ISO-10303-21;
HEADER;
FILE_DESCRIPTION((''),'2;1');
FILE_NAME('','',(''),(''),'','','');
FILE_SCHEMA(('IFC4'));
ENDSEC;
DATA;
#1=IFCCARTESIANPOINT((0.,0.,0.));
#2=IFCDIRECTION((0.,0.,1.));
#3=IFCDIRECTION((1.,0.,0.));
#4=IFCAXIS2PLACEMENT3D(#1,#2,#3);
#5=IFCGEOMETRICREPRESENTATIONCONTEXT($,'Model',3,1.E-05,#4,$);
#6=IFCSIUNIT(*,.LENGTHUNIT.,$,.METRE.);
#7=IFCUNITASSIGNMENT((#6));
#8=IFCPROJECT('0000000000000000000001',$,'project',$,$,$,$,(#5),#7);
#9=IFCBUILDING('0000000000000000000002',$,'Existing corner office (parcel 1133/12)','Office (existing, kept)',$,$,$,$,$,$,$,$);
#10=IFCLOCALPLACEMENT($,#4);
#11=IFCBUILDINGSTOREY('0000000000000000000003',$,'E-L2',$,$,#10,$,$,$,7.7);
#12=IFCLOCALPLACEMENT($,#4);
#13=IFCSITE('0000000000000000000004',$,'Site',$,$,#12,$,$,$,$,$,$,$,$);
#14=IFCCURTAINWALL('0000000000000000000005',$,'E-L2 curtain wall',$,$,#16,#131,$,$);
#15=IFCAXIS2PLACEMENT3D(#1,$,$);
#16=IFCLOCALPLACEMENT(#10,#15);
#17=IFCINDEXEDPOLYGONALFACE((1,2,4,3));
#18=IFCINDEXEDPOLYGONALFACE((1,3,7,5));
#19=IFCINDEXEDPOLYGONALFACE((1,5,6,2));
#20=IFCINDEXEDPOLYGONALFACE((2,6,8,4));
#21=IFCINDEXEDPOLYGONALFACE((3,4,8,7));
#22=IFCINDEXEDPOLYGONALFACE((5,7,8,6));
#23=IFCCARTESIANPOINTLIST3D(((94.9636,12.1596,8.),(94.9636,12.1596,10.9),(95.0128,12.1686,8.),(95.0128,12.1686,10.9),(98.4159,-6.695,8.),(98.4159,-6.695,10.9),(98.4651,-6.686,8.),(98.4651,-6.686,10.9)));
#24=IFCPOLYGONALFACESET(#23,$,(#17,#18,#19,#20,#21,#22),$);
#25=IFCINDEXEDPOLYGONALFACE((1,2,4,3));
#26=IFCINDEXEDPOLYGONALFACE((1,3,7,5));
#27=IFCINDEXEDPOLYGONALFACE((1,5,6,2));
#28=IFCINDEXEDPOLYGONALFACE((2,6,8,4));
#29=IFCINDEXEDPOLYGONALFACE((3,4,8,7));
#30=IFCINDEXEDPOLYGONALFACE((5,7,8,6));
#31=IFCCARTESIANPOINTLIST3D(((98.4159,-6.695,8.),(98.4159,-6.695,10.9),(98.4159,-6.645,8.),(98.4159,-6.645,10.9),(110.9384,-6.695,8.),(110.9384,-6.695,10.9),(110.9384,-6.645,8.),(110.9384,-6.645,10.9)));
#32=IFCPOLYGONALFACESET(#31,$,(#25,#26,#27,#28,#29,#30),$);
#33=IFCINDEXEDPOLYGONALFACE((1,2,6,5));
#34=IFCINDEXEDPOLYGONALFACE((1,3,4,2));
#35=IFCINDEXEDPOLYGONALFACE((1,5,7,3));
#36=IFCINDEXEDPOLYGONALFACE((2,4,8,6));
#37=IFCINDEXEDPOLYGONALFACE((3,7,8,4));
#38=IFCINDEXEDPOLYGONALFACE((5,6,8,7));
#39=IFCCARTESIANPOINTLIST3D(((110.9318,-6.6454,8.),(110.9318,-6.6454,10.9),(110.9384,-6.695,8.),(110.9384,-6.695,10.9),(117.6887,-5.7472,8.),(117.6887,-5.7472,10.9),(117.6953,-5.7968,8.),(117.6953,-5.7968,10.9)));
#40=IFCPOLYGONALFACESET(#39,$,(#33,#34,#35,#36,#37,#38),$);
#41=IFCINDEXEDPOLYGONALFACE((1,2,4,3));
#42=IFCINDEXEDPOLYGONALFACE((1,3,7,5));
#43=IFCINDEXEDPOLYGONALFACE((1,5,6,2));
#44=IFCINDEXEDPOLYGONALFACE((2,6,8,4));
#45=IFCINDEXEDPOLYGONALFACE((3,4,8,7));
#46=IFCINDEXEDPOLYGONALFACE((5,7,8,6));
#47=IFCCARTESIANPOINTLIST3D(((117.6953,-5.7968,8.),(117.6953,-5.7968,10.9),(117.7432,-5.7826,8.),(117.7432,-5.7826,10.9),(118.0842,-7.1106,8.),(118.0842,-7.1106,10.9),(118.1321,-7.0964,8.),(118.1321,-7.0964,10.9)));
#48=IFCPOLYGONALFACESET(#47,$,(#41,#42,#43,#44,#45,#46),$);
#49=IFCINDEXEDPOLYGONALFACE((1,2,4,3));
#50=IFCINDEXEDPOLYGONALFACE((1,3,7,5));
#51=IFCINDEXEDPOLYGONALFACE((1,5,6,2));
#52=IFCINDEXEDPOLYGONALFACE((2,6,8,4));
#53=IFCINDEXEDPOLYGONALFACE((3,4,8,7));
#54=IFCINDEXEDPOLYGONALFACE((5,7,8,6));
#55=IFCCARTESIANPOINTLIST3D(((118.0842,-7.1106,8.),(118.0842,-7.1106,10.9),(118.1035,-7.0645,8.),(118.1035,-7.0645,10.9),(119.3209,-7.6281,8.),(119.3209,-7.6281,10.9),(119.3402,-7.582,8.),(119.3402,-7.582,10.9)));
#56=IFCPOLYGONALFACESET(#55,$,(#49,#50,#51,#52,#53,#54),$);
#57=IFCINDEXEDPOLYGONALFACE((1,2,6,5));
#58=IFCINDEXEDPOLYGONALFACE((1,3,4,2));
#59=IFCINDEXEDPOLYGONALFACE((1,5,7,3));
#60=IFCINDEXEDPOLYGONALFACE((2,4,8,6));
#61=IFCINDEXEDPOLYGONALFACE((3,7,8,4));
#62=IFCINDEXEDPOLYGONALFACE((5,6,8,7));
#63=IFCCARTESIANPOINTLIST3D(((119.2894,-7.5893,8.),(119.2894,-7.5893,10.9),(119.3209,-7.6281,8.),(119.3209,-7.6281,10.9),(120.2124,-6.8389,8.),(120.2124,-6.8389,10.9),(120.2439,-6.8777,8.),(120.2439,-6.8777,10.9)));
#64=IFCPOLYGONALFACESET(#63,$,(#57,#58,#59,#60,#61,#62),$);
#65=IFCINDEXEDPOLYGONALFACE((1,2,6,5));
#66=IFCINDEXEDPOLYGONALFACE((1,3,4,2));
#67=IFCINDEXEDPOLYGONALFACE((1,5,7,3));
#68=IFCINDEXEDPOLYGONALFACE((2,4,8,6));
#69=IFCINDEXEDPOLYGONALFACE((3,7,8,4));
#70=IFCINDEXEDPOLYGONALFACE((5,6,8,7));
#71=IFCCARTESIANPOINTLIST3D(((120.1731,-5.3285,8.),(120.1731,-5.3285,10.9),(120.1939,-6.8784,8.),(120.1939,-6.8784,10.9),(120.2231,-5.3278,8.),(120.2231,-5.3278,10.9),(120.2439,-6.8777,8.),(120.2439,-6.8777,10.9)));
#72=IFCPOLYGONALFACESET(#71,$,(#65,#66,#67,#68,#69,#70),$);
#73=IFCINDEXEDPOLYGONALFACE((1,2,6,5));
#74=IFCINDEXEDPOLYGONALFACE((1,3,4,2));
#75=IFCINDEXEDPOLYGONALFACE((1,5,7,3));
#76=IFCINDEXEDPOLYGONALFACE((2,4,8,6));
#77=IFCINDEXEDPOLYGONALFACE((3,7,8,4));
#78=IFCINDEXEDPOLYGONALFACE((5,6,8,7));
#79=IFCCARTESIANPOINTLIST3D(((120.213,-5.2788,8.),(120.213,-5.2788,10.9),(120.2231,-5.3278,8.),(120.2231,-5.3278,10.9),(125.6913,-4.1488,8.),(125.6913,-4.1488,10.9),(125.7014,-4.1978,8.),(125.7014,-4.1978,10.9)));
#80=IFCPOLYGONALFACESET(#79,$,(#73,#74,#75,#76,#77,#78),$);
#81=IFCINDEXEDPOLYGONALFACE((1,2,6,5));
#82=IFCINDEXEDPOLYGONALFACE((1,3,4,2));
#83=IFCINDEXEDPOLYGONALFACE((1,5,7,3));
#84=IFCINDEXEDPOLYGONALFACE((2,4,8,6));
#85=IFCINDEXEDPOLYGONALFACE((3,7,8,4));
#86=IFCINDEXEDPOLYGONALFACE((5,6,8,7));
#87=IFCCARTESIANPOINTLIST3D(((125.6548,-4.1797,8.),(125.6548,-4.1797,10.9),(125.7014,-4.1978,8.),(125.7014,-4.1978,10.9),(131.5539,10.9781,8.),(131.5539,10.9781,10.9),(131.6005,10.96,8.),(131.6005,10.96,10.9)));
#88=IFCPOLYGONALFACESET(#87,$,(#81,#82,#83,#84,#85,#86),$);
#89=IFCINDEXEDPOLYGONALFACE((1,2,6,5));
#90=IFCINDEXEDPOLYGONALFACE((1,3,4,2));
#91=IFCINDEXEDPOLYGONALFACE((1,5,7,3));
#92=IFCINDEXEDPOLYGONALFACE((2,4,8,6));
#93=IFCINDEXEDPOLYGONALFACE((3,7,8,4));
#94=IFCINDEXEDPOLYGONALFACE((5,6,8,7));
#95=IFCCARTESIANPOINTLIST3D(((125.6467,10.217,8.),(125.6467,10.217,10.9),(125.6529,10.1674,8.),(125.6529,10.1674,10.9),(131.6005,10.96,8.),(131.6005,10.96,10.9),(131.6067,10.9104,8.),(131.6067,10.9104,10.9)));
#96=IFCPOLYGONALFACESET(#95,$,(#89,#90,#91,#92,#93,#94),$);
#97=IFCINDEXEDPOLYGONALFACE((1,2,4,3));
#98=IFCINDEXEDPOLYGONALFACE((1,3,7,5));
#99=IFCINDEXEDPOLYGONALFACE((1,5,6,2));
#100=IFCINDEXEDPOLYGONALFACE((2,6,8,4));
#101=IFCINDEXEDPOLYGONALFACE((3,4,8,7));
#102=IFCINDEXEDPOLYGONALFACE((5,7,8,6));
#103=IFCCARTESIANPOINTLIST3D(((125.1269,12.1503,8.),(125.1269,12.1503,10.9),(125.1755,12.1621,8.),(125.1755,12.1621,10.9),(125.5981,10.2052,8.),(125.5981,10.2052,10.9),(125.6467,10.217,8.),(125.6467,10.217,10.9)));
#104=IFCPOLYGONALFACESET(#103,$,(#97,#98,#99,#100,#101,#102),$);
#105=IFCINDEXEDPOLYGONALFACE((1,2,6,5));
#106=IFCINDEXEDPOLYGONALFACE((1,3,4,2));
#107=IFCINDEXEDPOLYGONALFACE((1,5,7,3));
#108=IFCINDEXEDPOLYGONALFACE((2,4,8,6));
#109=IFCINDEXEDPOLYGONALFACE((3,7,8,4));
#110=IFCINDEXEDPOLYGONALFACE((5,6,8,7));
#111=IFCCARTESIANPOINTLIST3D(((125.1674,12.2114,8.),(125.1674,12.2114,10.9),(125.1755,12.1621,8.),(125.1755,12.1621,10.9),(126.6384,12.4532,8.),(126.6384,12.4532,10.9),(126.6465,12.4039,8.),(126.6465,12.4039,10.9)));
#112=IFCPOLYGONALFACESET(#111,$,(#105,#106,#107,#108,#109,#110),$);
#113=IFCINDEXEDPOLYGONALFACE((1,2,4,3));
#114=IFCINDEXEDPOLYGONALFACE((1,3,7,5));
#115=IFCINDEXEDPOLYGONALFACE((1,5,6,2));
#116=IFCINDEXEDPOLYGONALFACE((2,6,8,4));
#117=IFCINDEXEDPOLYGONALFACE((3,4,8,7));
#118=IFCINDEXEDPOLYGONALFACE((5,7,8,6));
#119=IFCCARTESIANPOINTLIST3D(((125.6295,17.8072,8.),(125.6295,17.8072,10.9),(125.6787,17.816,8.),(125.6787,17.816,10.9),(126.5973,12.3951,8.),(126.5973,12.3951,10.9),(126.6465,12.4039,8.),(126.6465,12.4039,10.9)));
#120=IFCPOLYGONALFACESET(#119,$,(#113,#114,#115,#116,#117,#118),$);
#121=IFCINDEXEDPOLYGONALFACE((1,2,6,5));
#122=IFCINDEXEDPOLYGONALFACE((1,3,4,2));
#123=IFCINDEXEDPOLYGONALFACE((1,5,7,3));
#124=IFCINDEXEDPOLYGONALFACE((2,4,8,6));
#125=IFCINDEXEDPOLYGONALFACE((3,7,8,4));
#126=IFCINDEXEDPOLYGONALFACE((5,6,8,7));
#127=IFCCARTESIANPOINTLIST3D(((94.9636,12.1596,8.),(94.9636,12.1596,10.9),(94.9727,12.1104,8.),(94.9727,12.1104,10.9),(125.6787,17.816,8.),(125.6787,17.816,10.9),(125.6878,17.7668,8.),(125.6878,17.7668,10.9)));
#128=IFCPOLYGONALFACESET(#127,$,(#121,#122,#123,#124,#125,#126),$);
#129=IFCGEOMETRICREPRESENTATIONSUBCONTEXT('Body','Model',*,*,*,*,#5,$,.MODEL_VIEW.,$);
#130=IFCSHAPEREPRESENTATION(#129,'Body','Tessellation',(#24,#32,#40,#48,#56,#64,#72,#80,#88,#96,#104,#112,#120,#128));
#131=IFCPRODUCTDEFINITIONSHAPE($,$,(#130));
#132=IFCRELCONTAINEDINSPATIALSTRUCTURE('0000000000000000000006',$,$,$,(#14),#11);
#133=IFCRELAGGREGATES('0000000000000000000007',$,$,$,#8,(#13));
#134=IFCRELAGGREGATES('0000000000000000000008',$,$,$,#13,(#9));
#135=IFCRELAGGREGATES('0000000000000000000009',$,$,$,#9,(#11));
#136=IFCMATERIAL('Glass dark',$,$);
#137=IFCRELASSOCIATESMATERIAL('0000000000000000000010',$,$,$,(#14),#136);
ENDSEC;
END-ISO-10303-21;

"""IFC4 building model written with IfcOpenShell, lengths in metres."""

from ifc_helpers import new_model, si_unit, frame, origin_with_axes, place, context, subcontext, project, spatial, polyline, outline, extrude, material, element, save


model = new_model("IFC4")

# Units and contexts
model_context = context("Model", 3, precision=1e-05, world=origin_with_axes())
body_context = subcontext(model_context, "Body", "Model", "MODEL_VIEW")
ifc_project = project(units=[si_unit("LENGTHUNIT", "METRE")], contexts=[model_context])

# Site, building, storey
site_placement = place(None, origin_with_axes())
site = spatial("IfcSite", under=ifc_project, at=site_placement, Name="Site")
building = spatial("IfcBuilding", under=site, Name="Existing corner office (parcel 1133/12)", Description="Office (existing, kept)")
storey_placement = place(None, origin_with_axes())
storey = spatial("IfcBuildingStorey", under=building, at=storey_placement, Name="E-L2", Elevation=7.7)

# Curtain wall
ifc_material_1 = material(Name="Glass dark")
curtain_wall_placement = place(storey_placement, origin_with_axes())
element("IfcCurtainWall", 1, at=curtain_wall_placement, inside=storey, material=ifc_material_1, Name="E-L2 curtain wall", context=body_context, shape_type="SweptSolid", body=[
    extrude(outline(polyline([(94.9636, 12.1596), (98.4159, -6.695), (98.4651, -6.686), (95.0128, 12.1686), (94.9636, 12.1596)])), frame((0.0, 0.0, 8.0), z_axis=(0.0, 0.0, 1.0), x_axis=(1.0, 0.0, 0.0)), (0.0, 0.0, 1.0), 2.9),
    extrude(outline(polyline([(98.4159, -6.695), (110.9384, -6.695), (110.9384, -6.645), (98.4159, -6.645), (98.4159, -6.695)])), frame((0.0, 0.0, 8.0), z_axis=(0.0, 0.0, 1.0), x_axis=(1.0, 0.0, 0.0)), (0.0, 0.0, 1.0), 2.9),
    extrude(outline(polyline([(110.9384, -6.695), (117.6953, -5.7968), (117.6887, -5.7472), (110.9318, -6.6454), (110.9384, -6.695)])), frame((0.0, 0.0, 8.0), z_axis=(0.0, 0.0, 1.0), x_axis=(1.0, 0.0, 0.0)), (0.0, 0.0, 1.0), 2.9),
    extrude(outline(polyline([(117.6953, -5.7968), (118.0842, -7.1106), (118.1321, -7.0964), (117.7432, -5.7826), (117.6953, -5.7968)])), frame((0.0, 0.0, 8.0), z_axis=(0.0, 0.0, 1.0), x_axis=(1.0, 0.0, 0.0)), (0.0, 0.0, 1.0), 2.9),
    extrude(outline(polyline([(118.0842, -7.1106), (119.3209, -7.6281), (119.3402, -7.582), (118.1035, -7.0645), (118.0842, -7.1106)])), frame((0.0, 0.0, 8.0), z_axis=(0.0, 0.0, 1.0), x_axis=(1.0, 0.0, 0.0)), (0.0, 0.0, 1.0), 2.9),
    extrude(outline(polyline([(119.3209, -7.6281), (120.2439, -6.8777), (120.2124, -6.8389), (119.2894, -7.5893), (119.3209, -7.6281)])), frame((0.0, 0.0, 8.0), z_axis=(0.0, 0.0, 1.0), x_axis=(1.0, 0.0, 0.0)), (0.0, 0.0, 1.0), 2.9),
    extrude(outline(polyline([(120.2439, -6.8777), (120.2231, -5.3278), (120.1731, -5.3285), (120.1939, -6.8784), (120.2439, -6.8777)])), frame((0.0, 0.0, 8.0), z_axis=(0.0, 0.0, 1.0), x_axis=(1.0, 0.0, 0.0)), (0.0, 0.0, 1.0), 2.9),
    extrude(outline(polyline([(120.2231, -5.3278), (125.7014, -4.1978), (125.6913, -4.1488), (120.213, -5.2788), (120.2231, -5.3278)])), frame((0.0, 0.0, 8.0), z_axis=(0.0, 0.0, 1.0), x_axis=(1.0, 0.0, 0.0)), (0.0, 0.0, 1.0), 2.9),
    extrude(outline(polyline([(125.7014, -4.1978), (131.6005, 10.96), (131.5539, 10.9781), (125.6548, -4.1797), (125.7014, -4.1978)])), frame((0.0, 0.0, 8.0), z_axis=(0.0, 0.0, 1.0), x_axis=(1.0, 0.0, 0.0)), (0.0, 0.0, 1.0), 2.9),
    extrude(outline(polyline([(131.6005, 10.96), (125.6467, 10.217), (125.6529, 10.1674), (131.6067, 10.9104), (131.6005, 10.96)])), frame((0.0, 0.0, 8.0), z_axis=(0.0, 0.0, 1.0), x_axis=(1.0, 0.0, 0.0)), (0.0, 0.0, 1.0), 2.9),
    extrude(outline(polyline([(125.6467, 10.217), (125.1755, 12.1621), (125.1269, 12.1503), (125.5981, 10.2052), (125.6467, 10.217)])), frame((0.0, 0.0, 8.0), z_axis=(0.0, 0.0, 1.0), x_axis=(1.0, 0.0, 0.0)), (0.0, 0.0, 1.0), 2.9),
    extrude(outline(polyline([(125.1755, 12.1621), (126.6465, 12.4039), (126.6384, 12.4532), (125.1674, 12.2114), (125.1755, 12.1621)])), frame((0.0, 0.0, 8.0), z_axis=(0.0, 0.0, 1.0), x_axis=(1.0, 0.0, 0.0)), (0.0, 0.0, 1.0), 2.9),
    extrude(outline(polyline([(126.6465, 12.4039), (125.6787, 17.816), (125.6295, 17.8072), (126.5973, 12.3951), (126.6465, 12.4039)])), frame((0.0, 0.0, 8.0), z_axis=(0.0, 0.0, 1.0), x_axis=(1.0, 0.0, 0.0)), (0.0, 0.0, 1.0), 2.9),
    extrude(outline(polyline([(125.6787, 17.816), (94.9636, 12.1596), (94.9727, 12.1104), (125.6878, 17.7668), (125.6787, 17.816)])), frame((0.0, 0.0, 8.0), z_axis=(0.0, 0.0, 1.0), x_axis=(1.0, 0.0, 0.0)), (0.0, 0.0, 1.0), 2.9),
])

save(model, "model.ifc")
